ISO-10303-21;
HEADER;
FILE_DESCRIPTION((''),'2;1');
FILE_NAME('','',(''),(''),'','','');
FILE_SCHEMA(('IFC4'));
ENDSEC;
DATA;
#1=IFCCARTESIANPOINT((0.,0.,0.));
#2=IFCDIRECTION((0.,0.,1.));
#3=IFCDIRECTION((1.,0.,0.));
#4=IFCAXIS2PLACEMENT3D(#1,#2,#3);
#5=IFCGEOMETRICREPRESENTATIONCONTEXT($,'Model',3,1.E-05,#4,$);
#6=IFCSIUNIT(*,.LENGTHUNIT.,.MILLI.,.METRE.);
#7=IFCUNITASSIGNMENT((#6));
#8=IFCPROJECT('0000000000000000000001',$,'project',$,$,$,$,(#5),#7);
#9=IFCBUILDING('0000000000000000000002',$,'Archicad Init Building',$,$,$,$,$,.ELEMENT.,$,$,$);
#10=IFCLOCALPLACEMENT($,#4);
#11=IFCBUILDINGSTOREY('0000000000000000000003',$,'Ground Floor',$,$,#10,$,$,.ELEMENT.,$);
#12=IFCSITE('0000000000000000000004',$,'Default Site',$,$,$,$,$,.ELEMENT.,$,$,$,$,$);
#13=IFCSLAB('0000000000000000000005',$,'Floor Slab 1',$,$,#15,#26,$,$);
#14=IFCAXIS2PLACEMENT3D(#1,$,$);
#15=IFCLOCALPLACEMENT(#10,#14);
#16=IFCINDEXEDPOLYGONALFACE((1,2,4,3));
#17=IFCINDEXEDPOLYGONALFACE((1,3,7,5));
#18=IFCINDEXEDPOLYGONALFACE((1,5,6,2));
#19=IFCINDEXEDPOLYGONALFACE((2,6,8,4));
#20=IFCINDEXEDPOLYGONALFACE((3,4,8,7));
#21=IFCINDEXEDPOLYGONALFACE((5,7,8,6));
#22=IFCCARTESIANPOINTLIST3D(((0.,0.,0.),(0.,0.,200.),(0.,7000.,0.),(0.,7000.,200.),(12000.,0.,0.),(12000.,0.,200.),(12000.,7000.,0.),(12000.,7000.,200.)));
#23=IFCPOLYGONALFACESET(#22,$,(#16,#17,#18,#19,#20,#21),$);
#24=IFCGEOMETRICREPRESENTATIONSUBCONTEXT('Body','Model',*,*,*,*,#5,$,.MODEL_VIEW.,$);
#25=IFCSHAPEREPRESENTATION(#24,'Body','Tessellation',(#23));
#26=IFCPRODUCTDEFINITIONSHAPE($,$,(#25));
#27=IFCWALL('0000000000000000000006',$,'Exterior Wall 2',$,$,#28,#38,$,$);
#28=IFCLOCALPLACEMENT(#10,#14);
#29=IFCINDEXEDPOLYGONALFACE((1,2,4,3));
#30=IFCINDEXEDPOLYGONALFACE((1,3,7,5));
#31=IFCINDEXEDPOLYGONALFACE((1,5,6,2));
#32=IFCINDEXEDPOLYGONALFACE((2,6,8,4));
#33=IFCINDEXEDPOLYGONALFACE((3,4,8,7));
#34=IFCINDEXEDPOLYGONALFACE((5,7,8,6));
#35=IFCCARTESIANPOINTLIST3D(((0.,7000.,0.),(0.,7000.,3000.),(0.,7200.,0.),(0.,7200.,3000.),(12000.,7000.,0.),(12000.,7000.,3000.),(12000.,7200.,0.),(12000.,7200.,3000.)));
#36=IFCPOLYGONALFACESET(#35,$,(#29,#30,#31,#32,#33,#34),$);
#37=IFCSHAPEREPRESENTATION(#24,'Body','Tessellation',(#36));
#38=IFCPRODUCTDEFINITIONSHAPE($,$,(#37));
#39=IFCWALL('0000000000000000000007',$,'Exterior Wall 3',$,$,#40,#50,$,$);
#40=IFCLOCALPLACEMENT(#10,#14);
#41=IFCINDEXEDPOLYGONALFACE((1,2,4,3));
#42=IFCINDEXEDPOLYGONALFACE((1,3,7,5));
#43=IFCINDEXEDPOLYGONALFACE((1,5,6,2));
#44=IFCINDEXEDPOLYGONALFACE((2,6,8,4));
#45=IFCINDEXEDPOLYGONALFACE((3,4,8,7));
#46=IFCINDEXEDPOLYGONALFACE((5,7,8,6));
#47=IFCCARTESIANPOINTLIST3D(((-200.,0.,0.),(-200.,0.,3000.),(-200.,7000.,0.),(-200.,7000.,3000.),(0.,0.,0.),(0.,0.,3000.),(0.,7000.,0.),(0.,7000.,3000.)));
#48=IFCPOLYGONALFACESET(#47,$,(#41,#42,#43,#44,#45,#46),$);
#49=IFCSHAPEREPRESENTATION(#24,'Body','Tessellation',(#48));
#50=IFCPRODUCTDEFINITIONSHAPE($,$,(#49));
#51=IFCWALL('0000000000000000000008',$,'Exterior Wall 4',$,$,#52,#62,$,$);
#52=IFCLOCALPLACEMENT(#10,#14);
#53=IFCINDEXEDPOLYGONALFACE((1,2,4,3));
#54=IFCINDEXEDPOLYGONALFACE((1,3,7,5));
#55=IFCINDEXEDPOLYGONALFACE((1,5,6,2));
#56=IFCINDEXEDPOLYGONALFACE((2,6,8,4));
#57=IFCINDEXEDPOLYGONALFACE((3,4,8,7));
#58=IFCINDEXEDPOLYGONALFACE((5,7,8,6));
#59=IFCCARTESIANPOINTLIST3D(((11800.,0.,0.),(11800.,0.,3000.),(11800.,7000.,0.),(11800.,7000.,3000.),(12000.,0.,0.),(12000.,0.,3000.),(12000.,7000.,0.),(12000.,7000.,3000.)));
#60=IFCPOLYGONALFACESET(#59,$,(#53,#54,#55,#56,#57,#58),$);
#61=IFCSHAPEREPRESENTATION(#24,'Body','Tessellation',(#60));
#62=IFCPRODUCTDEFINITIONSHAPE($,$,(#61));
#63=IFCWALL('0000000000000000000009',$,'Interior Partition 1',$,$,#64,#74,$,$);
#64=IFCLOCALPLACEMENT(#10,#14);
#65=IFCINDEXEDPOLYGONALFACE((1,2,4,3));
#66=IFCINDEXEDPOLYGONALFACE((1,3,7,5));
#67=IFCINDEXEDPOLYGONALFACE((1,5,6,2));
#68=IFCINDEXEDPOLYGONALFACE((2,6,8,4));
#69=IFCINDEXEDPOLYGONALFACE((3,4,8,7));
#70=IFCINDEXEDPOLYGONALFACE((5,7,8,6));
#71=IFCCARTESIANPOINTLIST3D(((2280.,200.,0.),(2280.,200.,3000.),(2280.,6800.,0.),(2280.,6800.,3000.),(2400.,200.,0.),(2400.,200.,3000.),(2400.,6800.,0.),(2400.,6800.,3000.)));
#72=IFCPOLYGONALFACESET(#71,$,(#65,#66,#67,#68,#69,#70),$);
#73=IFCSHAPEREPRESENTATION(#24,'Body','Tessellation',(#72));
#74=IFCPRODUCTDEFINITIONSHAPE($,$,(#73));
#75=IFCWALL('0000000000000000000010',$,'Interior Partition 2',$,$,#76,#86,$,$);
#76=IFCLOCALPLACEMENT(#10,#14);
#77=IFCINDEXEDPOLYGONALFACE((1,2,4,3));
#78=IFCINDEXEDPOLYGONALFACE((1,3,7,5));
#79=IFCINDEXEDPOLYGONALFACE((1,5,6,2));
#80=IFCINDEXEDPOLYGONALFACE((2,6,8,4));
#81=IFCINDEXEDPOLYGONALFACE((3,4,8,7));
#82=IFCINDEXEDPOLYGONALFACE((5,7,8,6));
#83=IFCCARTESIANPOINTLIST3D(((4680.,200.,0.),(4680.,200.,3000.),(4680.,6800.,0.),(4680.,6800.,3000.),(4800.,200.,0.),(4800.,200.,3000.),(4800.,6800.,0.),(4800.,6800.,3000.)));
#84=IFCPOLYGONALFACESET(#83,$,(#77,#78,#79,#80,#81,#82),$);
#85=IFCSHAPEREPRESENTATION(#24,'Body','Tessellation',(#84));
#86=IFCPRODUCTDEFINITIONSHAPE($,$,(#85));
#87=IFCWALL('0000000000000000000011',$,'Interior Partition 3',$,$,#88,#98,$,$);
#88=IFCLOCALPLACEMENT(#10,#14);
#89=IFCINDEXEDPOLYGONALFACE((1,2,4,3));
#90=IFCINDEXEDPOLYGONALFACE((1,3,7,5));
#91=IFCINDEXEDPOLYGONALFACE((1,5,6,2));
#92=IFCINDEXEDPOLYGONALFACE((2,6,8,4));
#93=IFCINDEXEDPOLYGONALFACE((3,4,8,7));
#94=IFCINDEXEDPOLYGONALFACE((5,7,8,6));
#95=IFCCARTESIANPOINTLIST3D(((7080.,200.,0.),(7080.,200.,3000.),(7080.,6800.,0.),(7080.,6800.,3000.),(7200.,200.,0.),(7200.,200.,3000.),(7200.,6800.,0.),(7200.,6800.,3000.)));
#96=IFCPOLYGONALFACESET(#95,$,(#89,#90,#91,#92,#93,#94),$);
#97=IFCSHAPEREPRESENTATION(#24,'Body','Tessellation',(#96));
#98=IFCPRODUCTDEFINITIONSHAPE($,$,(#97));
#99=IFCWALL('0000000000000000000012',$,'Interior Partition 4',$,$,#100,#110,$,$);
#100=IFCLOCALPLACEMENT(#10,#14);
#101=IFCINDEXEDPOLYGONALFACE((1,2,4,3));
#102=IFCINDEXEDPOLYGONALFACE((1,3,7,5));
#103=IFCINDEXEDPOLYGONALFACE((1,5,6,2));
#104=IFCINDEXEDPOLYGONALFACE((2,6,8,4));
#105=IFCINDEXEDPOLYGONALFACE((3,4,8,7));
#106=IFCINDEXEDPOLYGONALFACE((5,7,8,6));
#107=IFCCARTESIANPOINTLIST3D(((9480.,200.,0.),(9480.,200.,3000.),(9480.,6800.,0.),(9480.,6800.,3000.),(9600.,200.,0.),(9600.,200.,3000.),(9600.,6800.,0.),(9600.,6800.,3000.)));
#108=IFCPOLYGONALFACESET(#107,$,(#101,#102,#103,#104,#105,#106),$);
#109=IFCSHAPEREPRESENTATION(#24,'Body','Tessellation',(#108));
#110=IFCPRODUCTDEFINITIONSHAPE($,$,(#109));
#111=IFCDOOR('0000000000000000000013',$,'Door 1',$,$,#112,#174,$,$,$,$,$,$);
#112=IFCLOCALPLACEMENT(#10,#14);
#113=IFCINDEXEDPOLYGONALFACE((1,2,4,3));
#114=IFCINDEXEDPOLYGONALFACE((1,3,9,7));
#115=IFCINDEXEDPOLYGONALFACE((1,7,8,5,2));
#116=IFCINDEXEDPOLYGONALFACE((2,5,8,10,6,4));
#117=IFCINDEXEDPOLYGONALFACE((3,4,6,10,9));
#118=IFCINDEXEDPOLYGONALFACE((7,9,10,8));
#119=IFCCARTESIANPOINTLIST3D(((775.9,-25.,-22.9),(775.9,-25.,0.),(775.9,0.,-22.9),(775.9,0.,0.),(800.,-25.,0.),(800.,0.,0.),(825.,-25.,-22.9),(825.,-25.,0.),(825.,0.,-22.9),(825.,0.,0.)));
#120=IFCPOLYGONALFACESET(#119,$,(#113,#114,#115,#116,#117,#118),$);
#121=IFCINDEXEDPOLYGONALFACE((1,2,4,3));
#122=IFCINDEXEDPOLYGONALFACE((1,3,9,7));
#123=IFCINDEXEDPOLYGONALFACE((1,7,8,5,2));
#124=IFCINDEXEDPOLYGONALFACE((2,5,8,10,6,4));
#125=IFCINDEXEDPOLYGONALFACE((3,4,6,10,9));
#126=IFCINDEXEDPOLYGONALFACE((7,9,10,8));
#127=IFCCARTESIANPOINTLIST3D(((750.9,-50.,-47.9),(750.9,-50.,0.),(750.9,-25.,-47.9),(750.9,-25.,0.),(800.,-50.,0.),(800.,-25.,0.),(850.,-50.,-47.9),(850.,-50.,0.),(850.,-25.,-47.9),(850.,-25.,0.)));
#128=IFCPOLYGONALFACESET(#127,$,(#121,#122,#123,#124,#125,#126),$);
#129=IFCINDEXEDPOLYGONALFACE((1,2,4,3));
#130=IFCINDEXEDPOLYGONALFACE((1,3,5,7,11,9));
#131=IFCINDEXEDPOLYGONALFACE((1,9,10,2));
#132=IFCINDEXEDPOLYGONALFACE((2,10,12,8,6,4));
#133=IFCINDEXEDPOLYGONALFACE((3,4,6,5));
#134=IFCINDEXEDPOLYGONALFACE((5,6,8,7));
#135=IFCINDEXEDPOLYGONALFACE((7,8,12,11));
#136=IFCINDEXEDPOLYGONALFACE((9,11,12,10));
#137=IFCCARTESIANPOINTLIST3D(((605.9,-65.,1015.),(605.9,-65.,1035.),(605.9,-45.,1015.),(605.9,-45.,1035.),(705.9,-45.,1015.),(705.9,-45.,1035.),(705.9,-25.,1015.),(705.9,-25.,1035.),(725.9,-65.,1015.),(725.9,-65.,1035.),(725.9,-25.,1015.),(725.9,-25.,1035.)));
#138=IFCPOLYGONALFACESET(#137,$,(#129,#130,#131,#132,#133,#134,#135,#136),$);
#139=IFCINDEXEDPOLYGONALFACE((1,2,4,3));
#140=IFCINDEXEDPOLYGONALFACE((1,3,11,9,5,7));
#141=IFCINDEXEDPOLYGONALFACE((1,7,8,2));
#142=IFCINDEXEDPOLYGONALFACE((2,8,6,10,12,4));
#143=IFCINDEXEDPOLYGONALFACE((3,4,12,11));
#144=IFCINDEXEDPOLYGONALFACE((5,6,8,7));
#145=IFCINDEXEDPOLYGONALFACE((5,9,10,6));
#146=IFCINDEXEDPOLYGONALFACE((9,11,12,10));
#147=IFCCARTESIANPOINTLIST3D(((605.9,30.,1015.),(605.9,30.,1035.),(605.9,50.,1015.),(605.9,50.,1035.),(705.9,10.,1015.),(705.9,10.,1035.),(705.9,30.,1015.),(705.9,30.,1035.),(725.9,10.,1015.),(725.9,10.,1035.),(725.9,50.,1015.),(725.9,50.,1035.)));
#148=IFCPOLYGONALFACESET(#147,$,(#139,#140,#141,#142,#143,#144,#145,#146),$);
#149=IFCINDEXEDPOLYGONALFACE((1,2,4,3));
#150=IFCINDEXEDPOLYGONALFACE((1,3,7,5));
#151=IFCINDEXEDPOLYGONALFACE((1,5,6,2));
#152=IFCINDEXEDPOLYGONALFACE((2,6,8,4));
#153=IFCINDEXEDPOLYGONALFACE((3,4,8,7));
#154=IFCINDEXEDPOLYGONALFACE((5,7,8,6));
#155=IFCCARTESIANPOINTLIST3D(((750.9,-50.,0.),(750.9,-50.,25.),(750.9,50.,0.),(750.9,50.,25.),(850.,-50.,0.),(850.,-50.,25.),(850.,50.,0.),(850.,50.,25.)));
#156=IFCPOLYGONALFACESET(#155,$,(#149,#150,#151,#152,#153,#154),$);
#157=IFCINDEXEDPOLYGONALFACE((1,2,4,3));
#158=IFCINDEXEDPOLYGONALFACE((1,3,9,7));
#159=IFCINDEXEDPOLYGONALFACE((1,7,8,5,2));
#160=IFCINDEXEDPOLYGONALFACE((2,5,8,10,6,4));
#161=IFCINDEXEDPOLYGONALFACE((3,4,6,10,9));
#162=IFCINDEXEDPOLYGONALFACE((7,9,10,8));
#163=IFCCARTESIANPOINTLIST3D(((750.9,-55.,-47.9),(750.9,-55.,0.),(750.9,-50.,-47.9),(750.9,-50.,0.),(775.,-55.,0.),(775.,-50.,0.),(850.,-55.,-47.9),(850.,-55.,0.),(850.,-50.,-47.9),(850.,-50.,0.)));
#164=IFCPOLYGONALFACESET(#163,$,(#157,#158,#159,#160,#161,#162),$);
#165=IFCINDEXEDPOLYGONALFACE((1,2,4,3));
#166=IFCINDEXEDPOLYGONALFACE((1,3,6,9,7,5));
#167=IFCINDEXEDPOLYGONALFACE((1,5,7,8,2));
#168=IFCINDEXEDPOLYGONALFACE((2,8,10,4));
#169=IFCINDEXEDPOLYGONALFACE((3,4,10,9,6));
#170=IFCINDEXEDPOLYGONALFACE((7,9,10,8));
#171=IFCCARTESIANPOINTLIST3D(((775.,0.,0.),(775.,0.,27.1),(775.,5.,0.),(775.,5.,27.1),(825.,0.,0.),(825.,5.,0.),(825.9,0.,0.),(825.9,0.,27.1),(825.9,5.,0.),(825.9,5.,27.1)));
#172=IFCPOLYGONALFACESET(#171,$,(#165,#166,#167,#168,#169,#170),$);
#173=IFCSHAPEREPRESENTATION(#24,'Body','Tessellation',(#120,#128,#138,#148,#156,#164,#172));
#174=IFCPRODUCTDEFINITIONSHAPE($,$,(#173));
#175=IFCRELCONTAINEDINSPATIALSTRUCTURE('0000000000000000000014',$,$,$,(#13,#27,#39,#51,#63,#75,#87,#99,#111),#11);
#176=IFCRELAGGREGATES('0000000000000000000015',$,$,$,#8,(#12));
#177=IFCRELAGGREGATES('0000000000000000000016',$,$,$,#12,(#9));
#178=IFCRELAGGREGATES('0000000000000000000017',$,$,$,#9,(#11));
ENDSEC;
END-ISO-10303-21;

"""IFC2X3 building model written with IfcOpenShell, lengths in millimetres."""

from ifc_helpers import new_model, si_unit, frame, origin_with_axes, place, context, subcontext, project, spatial, polyline, outline, extrude, element, save


model = new_model("IFC2X3")

# Units and contexts
model_context = context("Model", 3, precision=1e-05, world=origin_with_axes())
body_context = subcontext(model_context, "Body", "Model", "MODEL_VIEW")
ifc_project = project(units=[si_unit("LENGTHUNIT", "METRE", prefix="MILLI")], contexts=[model_context])

# Site, building, storey
site = spatial("IfcSite", under=ifc_project, Name="Default Site", CompositionType="ELEMENT")
building = spatial("IfcBuilding", under=site, Name="Archicad Init Building", CompositionType="ELEMENT")
storey_placement = place(None, origin_with_axes())
storey = spatial("IfcBuildingStorey", under=building, at=storey_placement, Name="Ground Floor", CompositionType="ELEMENT")

# Slab
slab_placement = place(storey_placement, origin_with_axes())
element("IfcSlab", 1, at=slab_placement, inside=storey, Name="Floor Slab 1", context=body_context, shape_type="SweptSolid", body=[
    extrude(outline(polyline([(0.0, 0.0), (12000.0, 0.0), (12000.0, 7000.0), (0.0, 7000.0), (0.0, 0.0)])), origin_with_axes(), (0.0, 0.0, 1.0), 200.0),
])

# Walls
wall_placement = place(storey_placement, frame((0.0, 7000.0, 0.0), z_axis=(0.0, 0.0, 1.0), x_axis=(1.0, 0.0, 0.0)))
element("IfcWall", 2, at=wall_placement, inside=storey, Name="Exterior Wall 2", context=body_context, shape_type="SweptSolid", body=[
    extrude(outline(polyline([(0.0, 0.0), (0.0, 200.0), (12000.0, 200.0), (12000.0, 0.0), (0.0, 0.0)])), origin_with_axes(), (0.0, 0.0, 1.0), 3000.0),
])
for number, where, z_axis, x_axis, name in (
    (3, (0.0, 0.0, 0.0), (0.0, 0.0, 1.0), (0.0, 1.0, 0.0), "Exterior Wall 3"),
    (4, (12000.0, 0.0, 0.0), (0.0, 0.0, 1.0), (0.0, 1.0, 0.0), "Exterior Wall 4"),
):
    element("IfcWall", number, at=place(storey_placement, frame(where, z_axis=z_axis, x_axis=x_axis)), inside=storey, Name=name, context=body_context, shape_type="SweptSolid", body=[
        extrude(outline(polyline([(0.0, 0.0), (0.0, 200.0), (7000.0, 200.0), (7000.0, 0.0), (0.0, 0.0)])), origin_with_axes(), (0.0, 0.0, 1.0), 3000.0),
    ])
for number, where, z_axis, x_axis, name in (
    (5, (2400.0, 200.0, 0.0), (0.0, 0.0, 1.0), (0.0, 1.0, 0.0), "Interior Partition 1"),
    (6, (4800.0, 200.0, 0.0), (0.0, 0.0, 1.0), (0.0, 1.0, 0.0), "Interior Partition 2"),
    (7, (7200.0, 200.0, 0.0), (0.0, 0.0, 1.0), (0.0, 1.0, 0.0), "Interior Partition 3"),
    (8, (9600.0, 200.0, 0.0), (0.0, 0.0, 1.0), (0.0, 1.0, 0.0), "Interior Partition 4"),
):
    element("IfcWall", number, at=place(storey_placement, frame(where, z_axis=z_axis, x_axis=x_axis)), inside=storey, Name=name, context=body_context, shape_type="SweptSolid", body=[
        extrude(outline(polyline([(0.0, 0.0), (0.0, 120.0), (6600.0, 120.0), (6600.0, 0.0), (0.0, 0.0)])), origin_with_axes(), (0.0, 0.0, 1.0), 3000.0),
    ])

# Door
door_1_placement = place(storey_placement, frame((800.0, -50.0, 0.0), z_axis=(0.0, 0.0, 1.0), x_axis=(1.0, 0.0, 0.0)))
element("IfcDoor", 9, at=door_1_placement, inside=storey, Name="Door 1", context=body_context, shape_type="SweptSolid", body=[
    extrude(outline(polyline([(0.0, 0.0), (0.0, 2.1), (0.9, 2.1), (0.9, 0.0), (-24.1, 0.0), (-24.1, -22.9), (25.0, -22.9), (25.0, 0.0), (0.0, 0.0)])), frame((0.0, 25.0, 0.0), z_axis=(0.0, -1.0, 0.0), x_axis=(1.0, 0.0, 0.0)), (0.0, 0.0, -1.0), 25.0),
    extrude(outline(polyline([(0.0, 0.0), (0.0, 2.1), (0.9, 2.1), (0.9, 0.0), (-49.1, 0.0), (-49.1, -47.9), (50.0, -47.9), (50.0, 0.0), (0.0, 0.0)])), frame((0.0, 0.0, 0.0), z_axis=(0.0, -1.0, 0.0), x_axis=(1.0, 0.0, 0.0)), (0.0, 0.0, -1.0), 25.0),
    extrude(outline(polyline([(0.0, 0.0), (-49.1, 0.0), (-49.1, 35.0), (0.0, 35.0), (0.0, 0.0)])), frame((25.0, 25.0, 25.0), z_axis=(0.0, 0.0, 1.0), x_axis=(1.0, 0.0, 0.0)), (0.0, 0.0, 1.0), -47.9),
    extrude(outline(polyline([(0.0, 0.0), (0.0, -40.0), (-120.0, -40.0), (-120.0, -20.0), (-20.0, -20.0), (-20.0, 0.0), (0.0, 0.0)])), frame((-74.1, 25.0, 1015.0), z_axis=(0.0, 0.0, 1.0), x_axis=(1.0, 0.0, 0.0)), (0.0, 0.0, 1.0), 20.0),
    extrude(outline(polyline([(0.0, 0.0), (0.0, 40.0), (-120.0, 40.0), (-120.0, 20.0), (-20.0, 20.0), (-20.0, 0.0), (0.0, 0.0)])), frame((-74.1, 60.0, 1015.0), z_axis=(0.0, 0.0, 1.0), x_axis=(1.0, 0.0, 0.0)), (0.0, 0.0, 1.0), 20.0),
    extrude(outline(polyline([(0.0, 0.0), (-99.1, 0.0), (-99.1, 100.0), (0.0, 100.0), (0.0, 0.0)])), frame((50.0, 0.0, 0.0), z_axis=(0.0, 0.0, 1.0), x_axis=(1.0, 0.0, 0.0)), (0.0, 0.0, 1.0), 25.0),
    extrude(outline(polyline([(0.0, 0.0), (0.0, 27.1), (50.9, 27.1), (50.9, 0.0), (-24.1, 0.0), (-24.1, -47.9), (75.0, -47.9), (75.0, 0.0), (0.0, 0.0)])), frame((-25.0, -5.0, 0.0), z_axis=(0.0, -1.0, 0.0), x_axis=(1.0, 0.0, 0.0)), (0.0, 0.0, -1.0), 5.0),
    extrude(outline(polyline([(0.0, 0.0), (0.0, 27.1), (50.9, 27.1), (50.9, 0.0), (0.9, 0.0), (0.9, -22.9), (50.0, -22.9), (50.0, 0.0), (0.0, 0.0)])), frame((-25.0, 50.0, 0.0), z_axis=(0.0, -1.0, 0.0), x_axis=(1.0, 0.0, 0.0)), (0.0, 0.0, -1.0), 5.0),
])

save(model, "model.ifc")
